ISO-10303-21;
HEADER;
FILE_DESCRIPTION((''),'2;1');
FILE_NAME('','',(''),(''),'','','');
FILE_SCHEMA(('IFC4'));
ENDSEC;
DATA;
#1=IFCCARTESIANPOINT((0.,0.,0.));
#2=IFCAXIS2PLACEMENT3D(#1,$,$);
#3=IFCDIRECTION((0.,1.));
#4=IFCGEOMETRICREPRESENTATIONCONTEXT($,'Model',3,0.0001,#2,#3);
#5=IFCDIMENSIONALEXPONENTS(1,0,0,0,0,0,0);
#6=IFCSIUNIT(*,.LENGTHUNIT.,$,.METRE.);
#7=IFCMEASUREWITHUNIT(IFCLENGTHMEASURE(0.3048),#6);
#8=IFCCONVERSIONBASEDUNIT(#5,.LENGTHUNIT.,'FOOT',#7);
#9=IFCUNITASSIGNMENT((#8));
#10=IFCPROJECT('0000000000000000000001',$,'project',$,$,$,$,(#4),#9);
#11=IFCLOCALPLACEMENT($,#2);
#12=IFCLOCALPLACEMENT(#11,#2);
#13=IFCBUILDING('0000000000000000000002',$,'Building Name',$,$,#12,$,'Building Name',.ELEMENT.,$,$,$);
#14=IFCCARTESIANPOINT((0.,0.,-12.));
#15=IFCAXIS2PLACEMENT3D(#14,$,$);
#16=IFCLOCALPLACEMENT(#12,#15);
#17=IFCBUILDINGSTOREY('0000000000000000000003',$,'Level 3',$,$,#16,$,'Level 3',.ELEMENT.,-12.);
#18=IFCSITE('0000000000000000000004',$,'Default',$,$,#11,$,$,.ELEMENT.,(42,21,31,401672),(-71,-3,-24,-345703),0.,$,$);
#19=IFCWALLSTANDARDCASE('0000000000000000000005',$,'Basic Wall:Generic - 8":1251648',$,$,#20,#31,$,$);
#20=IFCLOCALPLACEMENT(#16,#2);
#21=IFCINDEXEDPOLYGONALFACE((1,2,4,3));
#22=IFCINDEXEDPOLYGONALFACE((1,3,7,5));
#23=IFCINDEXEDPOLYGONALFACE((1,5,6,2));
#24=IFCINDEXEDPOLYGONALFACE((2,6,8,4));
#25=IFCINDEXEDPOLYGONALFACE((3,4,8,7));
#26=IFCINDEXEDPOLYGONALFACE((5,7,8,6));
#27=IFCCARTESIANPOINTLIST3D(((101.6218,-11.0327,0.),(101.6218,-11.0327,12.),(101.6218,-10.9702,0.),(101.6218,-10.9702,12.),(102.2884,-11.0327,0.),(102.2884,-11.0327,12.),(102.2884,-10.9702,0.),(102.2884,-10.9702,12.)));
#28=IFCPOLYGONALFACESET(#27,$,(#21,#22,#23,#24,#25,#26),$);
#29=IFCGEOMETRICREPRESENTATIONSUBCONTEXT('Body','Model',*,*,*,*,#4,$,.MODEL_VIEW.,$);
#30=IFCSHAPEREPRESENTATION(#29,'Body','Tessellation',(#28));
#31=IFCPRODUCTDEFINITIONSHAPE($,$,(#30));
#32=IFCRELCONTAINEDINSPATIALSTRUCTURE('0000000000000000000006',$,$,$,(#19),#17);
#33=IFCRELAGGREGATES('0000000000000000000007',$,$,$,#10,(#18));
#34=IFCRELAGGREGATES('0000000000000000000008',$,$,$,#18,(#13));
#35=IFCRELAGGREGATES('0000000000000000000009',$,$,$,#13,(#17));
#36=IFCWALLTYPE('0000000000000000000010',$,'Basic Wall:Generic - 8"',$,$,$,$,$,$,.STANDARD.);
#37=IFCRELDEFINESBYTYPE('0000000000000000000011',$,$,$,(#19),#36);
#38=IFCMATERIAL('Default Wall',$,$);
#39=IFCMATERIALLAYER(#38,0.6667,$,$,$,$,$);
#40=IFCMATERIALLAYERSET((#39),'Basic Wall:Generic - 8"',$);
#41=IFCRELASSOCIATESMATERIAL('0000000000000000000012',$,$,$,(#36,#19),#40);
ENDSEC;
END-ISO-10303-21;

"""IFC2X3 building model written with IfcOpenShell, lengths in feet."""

from ifc_helpers import new_model, entity, si_unit, converted_unit, direction, frame, frame_2d, origin, place, context, subcontext, project, spatial, rectangle, extrude, material, layer, layer_set, layer_usage, type_object, element, save


model = new_model("IFC2X3")

# Units and contexts
model_context = context("Model", 3, precision=0.0001, world=origin(), true_north=direction((0.0, 1.0)))
body_context = subcontext(model_context, "Body", "Model", "MODEL_VIEW")
ifc_project = project(units=[converted_unit("LENGTHUNIT", "FOOT", entity("IfcLengthMeasure", 0.3048), si_unit("LENGTHUNIT", "METRE"), dimensions=[1, 0, 0, 0, 0, 0, 0])], contexts=[model_context])

# Site, building, storey
site_placement = place(None, origin())
site = spatial("IfcSite", under=ifc_project, at=site_placement, Name="Default", CompositionType="ELEMENT", RefLatitude=(42, 21, 31, 401672), RefLongitude=(-71, -3, -24, -345703), RefElevation=0.0)
building_placement = place(site_placement, origin())
building = spatial("IfcBuilding", under=site, at=building_placement, Name="Building Name", LongName="Building Name", CompositionType="ELEMENT")
storey_placement = place(building_placement, frame((0.0, 0.0, -12.0)))
storey = spatial("IfcBuildingStorey", under=building, at=storey_placement, Name="Level 3", LongName="Level 3", CompositionType="ELEMENT", Elevation=-12.0)

# Wall
ifc_material_1 = material(Name="Default Wall")
ifc_layer_1 = layer(ifc_material_1, 0.6667)
ifc_layer_set_1 = layer_set([ifc_layer_1], Name="Basic Wall:Generic - 8\"")
wall_type_1 = type_object("IfcWallType", Name="Basic Wall:Generic - 8\"", PredefinedType="STANDARD", material=ifc_layer_set_1)
ifc_layer_usage_1 = layer_usage(ifc_layer_set_1, "AXIS2", "NEGATIVE", 0.3333)
wall_1_placement = place(storey_placement, frame((101.9551, -10.9702, 0.0), z_axis=(0.0, 0.0, 1.0), x_axis=(0.0, -1.0, 0.0)))
element("IfcWallStandardCase", 1, at=wall_1_placement, inside=storey, type_object=wall_type_1, material=ifc_layer_usage_1, Name="Basic Wall:Generic - 8\":1251648", context=body_context, shape_type="SweptSolid", body=[
    extrude(rectangle(XDim=0.0625, YDim=0.6667, at=frame_2d((0.0312, 0.0), x_axis=(-1.0, 0.0))), origin(), (0.0, 0.0, 1.0), 12.0),
])

save(model, "model.ifc")
